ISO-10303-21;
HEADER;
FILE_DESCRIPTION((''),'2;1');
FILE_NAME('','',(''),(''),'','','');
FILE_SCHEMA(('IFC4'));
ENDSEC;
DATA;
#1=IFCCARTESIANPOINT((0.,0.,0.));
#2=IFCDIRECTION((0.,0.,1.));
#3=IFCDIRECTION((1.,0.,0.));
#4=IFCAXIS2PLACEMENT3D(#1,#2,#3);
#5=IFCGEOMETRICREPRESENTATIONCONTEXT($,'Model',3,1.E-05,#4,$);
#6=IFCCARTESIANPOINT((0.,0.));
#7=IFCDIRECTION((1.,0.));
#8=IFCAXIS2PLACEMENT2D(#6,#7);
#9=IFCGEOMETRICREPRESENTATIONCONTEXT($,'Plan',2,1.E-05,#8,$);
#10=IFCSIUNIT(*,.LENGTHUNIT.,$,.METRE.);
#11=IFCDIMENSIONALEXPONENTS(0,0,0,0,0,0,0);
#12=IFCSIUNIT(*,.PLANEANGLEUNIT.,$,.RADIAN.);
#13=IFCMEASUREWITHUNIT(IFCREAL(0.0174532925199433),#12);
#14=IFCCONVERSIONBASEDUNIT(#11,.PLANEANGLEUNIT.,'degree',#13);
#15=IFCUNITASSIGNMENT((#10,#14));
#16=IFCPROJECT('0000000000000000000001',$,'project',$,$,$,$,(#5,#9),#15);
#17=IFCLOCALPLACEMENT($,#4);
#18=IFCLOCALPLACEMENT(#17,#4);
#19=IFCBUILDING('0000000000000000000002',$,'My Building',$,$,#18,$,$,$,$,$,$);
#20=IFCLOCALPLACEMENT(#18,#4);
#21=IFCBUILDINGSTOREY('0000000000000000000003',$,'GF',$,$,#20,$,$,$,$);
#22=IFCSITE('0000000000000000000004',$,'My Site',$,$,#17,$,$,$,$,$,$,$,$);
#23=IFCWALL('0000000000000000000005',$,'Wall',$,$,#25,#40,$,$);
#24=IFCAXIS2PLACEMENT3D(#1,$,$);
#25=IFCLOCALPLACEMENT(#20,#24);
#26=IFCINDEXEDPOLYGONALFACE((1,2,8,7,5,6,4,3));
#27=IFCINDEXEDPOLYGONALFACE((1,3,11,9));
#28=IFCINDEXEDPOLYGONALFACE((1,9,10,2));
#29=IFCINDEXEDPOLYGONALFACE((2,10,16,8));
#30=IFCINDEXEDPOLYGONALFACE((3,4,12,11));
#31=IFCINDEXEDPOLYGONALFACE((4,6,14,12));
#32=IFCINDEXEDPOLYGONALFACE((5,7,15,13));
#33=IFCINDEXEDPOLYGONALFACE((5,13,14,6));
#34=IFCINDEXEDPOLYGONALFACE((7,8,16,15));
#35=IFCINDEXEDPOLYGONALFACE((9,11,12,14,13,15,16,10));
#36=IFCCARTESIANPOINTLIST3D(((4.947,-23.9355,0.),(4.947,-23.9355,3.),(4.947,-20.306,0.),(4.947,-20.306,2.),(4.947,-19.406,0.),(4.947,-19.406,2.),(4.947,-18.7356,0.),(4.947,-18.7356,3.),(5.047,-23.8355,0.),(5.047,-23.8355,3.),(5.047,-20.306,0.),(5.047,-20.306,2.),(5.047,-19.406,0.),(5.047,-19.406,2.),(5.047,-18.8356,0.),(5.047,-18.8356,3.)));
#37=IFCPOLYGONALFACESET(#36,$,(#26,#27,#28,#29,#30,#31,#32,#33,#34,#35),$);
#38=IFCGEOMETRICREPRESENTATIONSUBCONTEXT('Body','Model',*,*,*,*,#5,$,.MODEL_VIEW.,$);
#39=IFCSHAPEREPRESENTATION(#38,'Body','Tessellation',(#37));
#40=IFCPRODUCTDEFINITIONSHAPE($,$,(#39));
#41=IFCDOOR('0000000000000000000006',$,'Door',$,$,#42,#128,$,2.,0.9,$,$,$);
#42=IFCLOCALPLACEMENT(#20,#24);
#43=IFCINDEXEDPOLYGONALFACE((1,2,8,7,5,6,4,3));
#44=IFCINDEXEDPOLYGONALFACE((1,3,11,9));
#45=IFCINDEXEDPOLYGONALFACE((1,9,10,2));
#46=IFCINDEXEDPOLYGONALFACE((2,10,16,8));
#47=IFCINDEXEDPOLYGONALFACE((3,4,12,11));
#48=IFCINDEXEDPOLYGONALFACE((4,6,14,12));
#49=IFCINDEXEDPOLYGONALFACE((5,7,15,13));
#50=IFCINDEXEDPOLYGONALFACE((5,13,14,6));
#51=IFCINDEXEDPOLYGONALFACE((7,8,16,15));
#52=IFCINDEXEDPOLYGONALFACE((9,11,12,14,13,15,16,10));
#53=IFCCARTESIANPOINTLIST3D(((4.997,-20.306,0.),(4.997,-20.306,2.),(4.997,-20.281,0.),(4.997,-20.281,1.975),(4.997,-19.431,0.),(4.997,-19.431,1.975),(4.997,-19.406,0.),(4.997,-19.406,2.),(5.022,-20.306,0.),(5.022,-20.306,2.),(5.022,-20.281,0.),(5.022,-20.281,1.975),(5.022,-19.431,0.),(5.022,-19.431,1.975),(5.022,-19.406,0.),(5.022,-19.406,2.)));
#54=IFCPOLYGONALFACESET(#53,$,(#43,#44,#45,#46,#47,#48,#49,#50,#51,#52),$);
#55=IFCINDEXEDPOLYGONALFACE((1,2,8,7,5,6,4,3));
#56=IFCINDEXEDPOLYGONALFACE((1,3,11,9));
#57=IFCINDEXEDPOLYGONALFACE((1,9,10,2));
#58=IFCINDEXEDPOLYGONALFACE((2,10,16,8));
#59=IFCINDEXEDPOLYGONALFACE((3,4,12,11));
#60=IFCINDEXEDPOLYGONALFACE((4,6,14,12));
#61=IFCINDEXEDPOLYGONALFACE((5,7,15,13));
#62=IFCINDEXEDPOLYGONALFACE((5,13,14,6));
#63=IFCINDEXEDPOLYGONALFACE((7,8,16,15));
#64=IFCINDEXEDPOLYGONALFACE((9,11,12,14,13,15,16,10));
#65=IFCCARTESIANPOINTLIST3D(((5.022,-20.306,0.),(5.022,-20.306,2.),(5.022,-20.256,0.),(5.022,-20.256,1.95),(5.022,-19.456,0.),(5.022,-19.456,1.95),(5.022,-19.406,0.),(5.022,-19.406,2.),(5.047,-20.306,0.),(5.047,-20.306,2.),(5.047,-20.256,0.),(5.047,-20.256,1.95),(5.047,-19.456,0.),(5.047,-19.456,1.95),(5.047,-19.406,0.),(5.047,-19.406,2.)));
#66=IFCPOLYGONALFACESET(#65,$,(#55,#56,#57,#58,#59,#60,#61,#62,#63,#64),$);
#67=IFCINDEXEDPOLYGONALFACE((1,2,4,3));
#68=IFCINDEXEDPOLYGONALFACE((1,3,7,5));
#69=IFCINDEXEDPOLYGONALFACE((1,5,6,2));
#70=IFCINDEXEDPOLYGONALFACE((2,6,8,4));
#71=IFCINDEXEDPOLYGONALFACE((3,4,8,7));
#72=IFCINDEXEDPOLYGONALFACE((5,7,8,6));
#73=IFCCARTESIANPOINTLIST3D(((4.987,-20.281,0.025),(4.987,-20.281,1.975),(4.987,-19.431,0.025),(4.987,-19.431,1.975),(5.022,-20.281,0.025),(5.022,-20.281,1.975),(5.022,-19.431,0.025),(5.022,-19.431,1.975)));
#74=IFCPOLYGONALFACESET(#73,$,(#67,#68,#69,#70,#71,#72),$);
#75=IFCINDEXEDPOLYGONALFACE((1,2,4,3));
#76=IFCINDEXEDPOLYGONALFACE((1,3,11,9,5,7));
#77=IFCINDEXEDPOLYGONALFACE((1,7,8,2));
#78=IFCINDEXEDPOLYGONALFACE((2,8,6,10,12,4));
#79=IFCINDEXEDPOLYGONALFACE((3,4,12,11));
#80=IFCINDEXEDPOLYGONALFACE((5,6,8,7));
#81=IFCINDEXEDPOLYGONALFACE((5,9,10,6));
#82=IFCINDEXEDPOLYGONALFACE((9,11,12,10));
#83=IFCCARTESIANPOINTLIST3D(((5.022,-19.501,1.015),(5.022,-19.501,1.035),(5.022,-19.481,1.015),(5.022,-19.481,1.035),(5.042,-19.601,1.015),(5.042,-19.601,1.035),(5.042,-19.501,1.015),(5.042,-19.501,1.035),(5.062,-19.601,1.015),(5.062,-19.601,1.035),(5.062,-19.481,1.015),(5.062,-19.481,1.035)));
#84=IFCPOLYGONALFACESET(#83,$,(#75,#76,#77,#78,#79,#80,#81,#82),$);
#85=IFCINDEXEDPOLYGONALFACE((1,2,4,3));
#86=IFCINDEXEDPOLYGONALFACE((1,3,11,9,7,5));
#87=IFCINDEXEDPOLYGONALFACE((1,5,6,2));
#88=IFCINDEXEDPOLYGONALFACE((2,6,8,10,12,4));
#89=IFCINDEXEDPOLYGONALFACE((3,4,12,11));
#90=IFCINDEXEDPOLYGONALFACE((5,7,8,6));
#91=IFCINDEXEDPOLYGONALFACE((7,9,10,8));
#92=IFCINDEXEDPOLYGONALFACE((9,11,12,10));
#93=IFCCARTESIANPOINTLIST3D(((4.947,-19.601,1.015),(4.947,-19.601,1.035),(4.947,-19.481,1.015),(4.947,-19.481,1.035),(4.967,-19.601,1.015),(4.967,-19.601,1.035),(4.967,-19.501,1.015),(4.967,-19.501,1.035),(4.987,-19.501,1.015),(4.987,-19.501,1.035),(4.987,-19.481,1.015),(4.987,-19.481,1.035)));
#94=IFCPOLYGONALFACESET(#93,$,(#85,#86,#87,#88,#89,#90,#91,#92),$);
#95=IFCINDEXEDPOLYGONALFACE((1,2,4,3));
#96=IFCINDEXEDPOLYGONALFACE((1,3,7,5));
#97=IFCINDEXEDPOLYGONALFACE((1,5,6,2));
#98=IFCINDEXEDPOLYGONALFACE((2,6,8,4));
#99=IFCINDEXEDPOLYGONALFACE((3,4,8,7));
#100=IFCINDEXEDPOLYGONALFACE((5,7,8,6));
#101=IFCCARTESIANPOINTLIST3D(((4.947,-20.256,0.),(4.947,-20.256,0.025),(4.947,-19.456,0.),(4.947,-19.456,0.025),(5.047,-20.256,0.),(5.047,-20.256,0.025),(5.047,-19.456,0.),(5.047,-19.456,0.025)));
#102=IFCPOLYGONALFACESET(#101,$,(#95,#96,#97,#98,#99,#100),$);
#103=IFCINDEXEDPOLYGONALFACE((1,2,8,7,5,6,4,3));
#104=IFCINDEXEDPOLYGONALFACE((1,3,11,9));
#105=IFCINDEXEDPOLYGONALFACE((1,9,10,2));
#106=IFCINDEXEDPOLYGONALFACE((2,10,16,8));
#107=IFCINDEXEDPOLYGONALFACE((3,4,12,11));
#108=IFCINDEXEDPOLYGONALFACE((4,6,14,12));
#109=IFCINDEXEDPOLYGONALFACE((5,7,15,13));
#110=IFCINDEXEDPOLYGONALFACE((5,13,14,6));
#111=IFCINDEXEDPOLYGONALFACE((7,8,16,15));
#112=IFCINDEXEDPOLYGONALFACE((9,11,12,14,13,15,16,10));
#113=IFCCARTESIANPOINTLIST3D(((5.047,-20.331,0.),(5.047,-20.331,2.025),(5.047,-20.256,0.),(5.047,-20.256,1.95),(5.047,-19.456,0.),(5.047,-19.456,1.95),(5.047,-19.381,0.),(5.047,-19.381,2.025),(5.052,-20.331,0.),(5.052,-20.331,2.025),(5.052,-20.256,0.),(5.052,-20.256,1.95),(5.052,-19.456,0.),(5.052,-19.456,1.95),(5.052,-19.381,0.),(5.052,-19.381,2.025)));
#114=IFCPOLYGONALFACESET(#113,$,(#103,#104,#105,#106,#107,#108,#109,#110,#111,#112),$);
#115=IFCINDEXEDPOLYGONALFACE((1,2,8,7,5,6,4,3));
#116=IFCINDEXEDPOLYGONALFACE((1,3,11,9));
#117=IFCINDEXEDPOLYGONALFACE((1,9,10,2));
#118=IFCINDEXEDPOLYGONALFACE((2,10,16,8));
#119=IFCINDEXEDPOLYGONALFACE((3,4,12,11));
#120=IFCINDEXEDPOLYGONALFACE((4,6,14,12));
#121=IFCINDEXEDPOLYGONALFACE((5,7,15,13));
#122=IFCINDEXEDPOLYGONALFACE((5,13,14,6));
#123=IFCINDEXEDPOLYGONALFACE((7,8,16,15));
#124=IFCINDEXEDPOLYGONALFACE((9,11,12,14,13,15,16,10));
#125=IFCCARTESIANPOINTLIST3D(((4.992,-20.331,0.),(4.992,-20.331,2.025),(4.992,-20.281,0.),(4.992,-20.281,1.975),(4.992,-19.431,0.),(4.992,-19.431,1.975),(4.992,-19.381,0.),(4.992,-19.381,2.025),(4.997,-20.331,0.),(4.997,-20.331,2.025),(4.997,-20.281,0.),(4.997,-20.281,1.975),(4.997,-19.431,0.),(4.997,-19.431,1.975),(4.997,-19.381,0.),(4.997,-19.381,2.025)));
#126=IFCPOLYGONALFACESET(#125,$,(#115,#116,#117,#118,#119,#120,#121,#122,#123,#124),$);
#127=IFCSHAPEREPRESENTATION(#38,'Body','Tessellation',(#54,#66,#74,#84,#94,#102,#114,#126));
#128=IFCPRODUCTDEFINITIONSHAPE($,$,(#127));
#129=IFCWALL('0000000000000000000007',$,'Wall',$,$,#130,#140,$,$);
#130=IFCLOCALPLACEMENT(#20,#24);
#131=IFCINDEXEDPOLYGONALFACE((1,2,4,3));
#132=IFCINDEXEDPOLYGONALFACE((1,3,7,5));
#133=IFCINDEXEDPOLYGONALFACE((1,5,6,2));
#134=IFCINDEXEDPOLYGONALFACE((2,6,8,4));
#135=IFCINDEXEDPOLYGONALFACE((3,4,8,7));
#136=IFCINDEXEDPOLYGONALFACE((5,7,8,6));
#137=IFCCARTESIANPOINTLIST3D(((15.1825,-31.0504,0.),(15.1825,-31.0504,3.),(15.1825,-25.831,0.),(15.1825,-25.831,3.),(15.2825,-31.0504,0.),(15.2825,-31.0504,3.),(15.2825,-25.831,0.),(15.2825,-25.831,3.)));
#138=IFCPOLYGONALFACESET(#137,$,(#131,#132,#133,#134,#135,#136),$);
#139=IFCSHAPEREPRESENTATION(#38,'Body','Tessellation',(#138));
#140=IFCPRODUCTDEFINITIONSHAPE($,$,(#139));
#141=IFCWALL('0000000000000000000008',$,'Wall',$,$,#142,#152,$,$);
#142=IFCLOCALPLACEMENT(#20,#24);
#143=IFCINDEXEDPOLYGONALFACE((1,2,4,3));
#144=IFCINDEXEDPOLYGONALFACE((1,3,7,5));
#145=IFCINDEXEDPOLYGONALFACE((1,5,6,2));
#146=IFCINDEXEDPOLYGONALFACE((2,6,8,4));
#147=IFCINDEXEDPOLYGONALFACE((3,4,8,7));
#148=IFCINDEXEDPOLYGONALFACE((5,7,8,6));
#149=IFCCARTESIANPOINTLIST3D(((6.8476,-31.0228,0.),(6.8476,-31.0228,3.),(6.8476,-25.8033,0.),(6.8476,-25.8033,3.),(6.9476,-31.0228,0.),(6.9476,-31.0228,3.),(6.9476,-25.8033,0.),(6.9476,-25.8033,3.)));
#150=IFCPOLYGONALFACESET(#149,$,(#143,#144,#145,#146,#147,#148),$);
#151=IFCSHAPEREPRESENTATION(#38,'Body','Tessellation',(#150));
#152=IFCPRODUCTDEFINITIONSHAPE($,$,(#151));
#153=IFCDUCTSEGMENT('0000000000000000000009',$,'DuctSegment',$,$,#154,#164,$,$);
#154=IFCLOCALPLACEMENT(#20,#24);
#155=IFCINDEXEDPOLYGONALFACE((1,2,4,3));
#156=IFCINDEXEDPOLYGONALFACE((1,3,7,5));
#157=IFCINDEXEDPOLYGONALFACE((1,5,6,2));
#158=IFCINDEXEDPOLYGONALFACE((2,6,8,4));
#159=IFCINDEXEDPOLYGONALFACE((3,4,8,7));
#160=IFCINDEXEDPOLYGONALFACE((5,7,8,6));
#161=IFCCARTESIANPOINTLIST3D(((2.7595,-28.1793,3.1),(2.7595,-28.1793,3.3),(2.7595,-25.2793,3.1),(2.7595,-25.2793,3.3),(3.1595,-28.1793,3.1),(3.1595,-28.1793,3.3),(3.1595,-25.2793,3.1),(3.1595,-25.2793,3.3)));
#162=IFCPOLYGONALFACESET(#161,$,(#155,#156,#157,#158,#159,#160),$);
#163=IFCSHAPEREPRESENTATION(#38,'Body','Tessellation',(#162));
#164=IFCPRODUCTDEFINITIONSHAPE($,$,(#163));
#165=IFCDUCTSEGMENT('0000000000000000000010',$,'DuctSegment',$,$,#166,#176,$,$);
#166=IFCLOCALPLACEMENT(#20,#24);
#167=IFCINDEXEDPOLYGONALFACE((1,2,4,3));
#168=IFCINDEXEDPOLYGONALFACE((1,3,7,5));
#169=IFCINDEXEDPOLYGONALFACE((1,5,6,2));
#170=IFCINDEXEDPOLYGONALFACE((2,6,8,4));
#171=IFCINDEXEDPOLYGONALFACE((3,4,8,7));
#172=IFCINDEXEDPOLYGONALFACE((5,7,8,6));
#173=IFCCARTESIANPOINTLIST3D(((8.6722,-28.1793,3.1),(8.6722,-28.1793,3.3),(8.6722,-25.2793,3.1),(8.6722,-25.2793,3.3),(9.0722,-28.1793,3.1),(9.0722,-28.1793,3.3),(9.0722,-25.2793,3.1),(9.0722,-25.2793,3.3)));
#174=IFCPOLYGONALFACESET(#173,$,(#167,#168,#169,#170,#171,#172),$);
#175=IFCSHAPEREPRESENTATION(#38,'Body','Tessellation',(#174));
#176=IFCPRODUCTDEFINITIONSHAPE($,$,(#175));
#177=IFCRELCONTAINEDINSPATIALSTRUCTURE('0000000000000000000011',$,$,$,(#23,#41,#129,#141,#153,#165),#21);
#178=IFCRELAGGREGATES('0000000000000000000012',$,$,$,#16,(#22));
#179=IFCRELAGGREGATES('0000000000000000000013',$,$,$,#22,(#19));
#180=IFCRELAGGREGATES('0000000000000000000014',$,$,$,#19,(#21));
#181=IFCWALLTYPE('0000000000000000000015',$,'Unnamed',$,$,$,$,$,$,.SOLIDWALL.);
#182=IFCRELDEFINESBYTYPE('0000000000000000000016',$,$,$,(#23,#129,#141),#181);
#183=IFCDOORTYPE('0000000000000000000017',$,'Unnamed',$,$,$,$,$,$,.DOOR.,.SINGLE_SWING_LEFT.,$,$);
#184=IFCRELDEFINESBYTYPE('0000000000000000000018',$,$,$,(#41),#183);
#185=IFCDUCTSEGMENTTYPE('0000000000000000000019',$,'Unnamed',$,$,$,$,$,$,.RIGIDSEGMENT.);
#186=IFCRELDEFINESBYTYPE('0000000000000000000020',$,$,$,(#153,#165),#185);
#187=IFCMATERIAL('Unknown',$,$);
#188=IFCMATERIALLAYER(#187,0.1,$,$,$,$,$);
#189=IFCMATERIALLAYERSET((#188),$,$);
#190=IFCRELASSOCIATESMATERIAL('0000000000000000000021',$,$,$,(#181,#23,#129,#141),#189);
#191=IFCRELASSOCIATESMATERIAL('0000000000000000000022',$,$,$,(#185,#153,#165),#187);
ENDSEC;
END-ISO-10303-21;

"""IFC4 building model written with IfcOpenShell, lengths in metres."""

from ifc_helpers import new_model, entity, si_unit, converted_unit, frame, origin_with_axes, origin_2d_with_axis, place, context, subcontext, project, spatial, line, indexed_curve, rectangle, outline, extrude, shape, source, transform, mapped, material, layer, layer_set, layer_usage, material_profile, profile_set, profile_usage, type_object, type_shapes, element, fill, save


model = new_model("IFC4")

# Units and contexts
model_context = context("Model", 3, precision=1e-05, world=origin_with_axes())
plan_context = context("Plan", 2, precision=1e-05, world=origin_2d_with_axis())
body_context_1 = subcontext(model_context, "Body", "Model", "MODEL_VIEW")
body_context_2 = subcontext(plan_context, "Body", "Plan", "PLAN_VIEW")
ifc_project = project(units=[si_unit("LENGTHUNIT", "METRE"), converted_unit("PLANEANGLEUNIT", "degree", entity("IfcReal", 0.0174532925199433), si_unit("PLANEANGLEUNIT", "RADIAN"), dimensions=[0, 0, 0, 0, 0, 0, 0])], contexts=[model_context, plan_context])

# Site, building, storey
site_placement = place(None, origin_with_axes())
site = spatial("IfcSite", under=ifc_project, at=site_placement, Name="My Site")
building_placement = place(site_placement, origin_with_axes())
building = spatial("IfcBuilding", under=site, at=building_placement, Name="My Building")
storey_placement = place(building_placement, origin_with_axes())
storey = spatial("IfcBuildingStorey", under=building, at=storey_placement, Name="GF")

# Shared definitions
ifc_material = material(Name="Unknown")
ifc_layer = layer(ifc_material, 0.1)
ifc_layer_set = layer_set([ifc_layer])
wall_type = type_object("IfcWallType", Name="Unnamed", PredefinedType="SOLIDWALL", material=ifc_layer_set)

# Shared definitions
shared_shape_1 = source(origin_with_axes(), body_context_1, "Body", "SweptSolid", [
    extrude(outline(indexed_curve([(0.0, 0.0), (0.9, 0.0), (0.9, 2.0), (0.0, 2.0)], segments=[line(1, 2, 3, 4, 1)])), frame((0.0, -0.6, 0.0), z_axis=(0.0, -1.0, 0.0), x_axis=(1.0, 0.0, 0.0)), (0.0, 0.0, -1.0), 1.2),
])
door_type = type_object("IfcDoorType", Name="Unnamed", OperationType="SINGLE_SWING_LEFT", PredefinedType="DOOR")
shared_shape_2 = source(origin_with_axes(), body_context_1, "Body", "SweptSolid", [
    extrude(outline(indexed_curve([(0.0, 0.0), (0.0, 2.0), (0.9, 2.0), (0.9, 0.0), (0.875, 0.0), (0.875, 1.975), (0.025, 1.975), (0.025, 0.0)], segments=[line(1, 2, 3, 4, 5, 6, 7, 8, 1)])), frame((0.0, 0.025, 0.0), z_axis=(0.0, -1.0, 0.0), x_axis=(1.0, 0.0, 0.0)), (0.0, 0.0, -1.0), 0.025),
    extrude(outline(indexed_curve([(0.0, 0.0), (0.0, 2.0), (0.9, 2.0), (0.9, 0.0), (0.85, 0.0), (0.85, 1.95), (0.05, 1.95), (0.05, 0.0)], segments=[line(1, 2, 3, 4, 5, 6, 7, 8, 1)])), frame((0.0, 0.0, 0.0), z_axis=(0.0, -1.0, 0.0), x_axis=(1.0, 0.0, 0.0)), (0.0, 0.0, -1.0), 0.025),
    extrude(outline(indexed_curve([(0.0, 0.0), (0.85, 0.0), (0.85, 0.035), (0.0, 0.035)], segments=[line(1, 2, 3, 4, 1)])), frame((0.025, 0.025, 0.025), z_axis=(0.0, 0.0, 1.0), x_axis=(1.0, 0.0, 0.0)), (0.0, 0.0, 1.0), 1.95),
    extrude(outline(indexed_curve([(0.0, 0.0), (0.0, -0.04), (-0.12, -0.04), (-0.12, -0.02), (-0.02, -0.02), (-0.02, 0.0)], segments=[line(1, 2, 3, 4, 5, 6, 1)])), frame((0.825, 0.025, 1.015), z_axis=(0.0, 0.0, 1.0), x_axis=(1.0, 0.0, 0.0)), (0.0, 0.0, 1.0), 0.02),
    extrude(outline(indexed_curve([(0.0, 0.0), (0.0, 0.04), (-0.12, 0.04), (-0.12, 0.02), (-0.02, 0.02), (-0.02, 0.0)], segments=[line(1, 2, 3, 4, 5, 6, 1)])), frame((0.825, 0.06, 1.015), z_axis=(0.0, 0.0, 1.0), x_axis=(1.0, 0.0, 0.0)), (0.0, 0.0, 1.0), 0.02),
    extrude(outline(indexed_curve([(0.0, 0.0), (0.8, 0.0), (0.8, 0.1), (0.0, 0.1)], segments=[line(1, 2, 3, 4, 1)])), frame((0.05, 0.0, 0.0), z_axis=(0.0, 0.0, 1.0), x_axis=(1.0, 0.0, 0.0)), (0.0, 0.0, 1.0), 0.025),
    extrude(outline(indexed_curve([(0.0, 0.0), (0.0, 2.025), (0.95, 2.025), (0.95, 0.0), (0.875, 0.0), (0.875, 1.95), (0.075, 1.95), (0.075, 0.0)], segments=[line(1, 2, 3, 4, 5, 6, 7, 8, 1)])), frame((-0.025, -0.005, 0.0), z_axis=(0.0, -1.0, 0.0), x_axis=(1.0, 0.0, 0.0)), (0.0, 0.0, -1.0), 0.005),
    extrude(outline(indexed_curve([(0.0, 0.0), (0.0, 2.025), (0.95, 2.025), (0.95, 0.0), (0.9, 0.0), (0.9, 1.975), (0.05, 1.975), (0.05, 0.0)], segments=[line(1, 2, 3, 4, 5, 6, 7, 8, 1)])), frame((-0.025, 0.05, 0.0), z_axis=(0.0, -1.0, 0.0), x_axis=(1.0, 0.0, 0.0)), (0.0, 0.0, -1.0), 0.005),
])
shared_shape_3 = source(origin_with_axes(), body_context_2, "Body", "Curve2D", [
    entity("IfcIndexedPolyCurve", entity("IfcCartesianPointList2D", [[0.0, 0.0], [0.0, 0.05], [0.025, 0.05], [0.025, 0.025], [0.05, 0.025], [0.05, 0.0]]), [entity("IfcLineIndex", [1, 2, 3, 4, 5, 6, 1])]),
    entity("IfcIndexedPolyCurve", entity("IfcCartesianPointList2D", [[0.9, 0.0], [0.9, 0.05], [0.875, 0.05], [0.875, 0.025], [0.85, 0.025], [0.85, 0.0]]), [entity("IfcLineIndex", [1, 2, 3, 4, 5, 6, 1])]),
    entity("IfcTrimmedCurve", entity("IfcEllipse", entity("IfcAxis2Placement2D", entity("IfcCartesianPoint", [0.06, 0.05]), entity("IfcDirection", [1.0, 0.0])), 0.815, 0.85), [entity("IfcCartesianPoint", [0.875, 0.05])], [entity("IfcCartesianPoint", [0.06, 0.9])], True, "CARTESIAN"),
    entity("IfcIndexedPolyCurve", entity("IfcCartesianPointList2D", [[0.025, 0.05], [0.06, 0.05], [0.06, 0.9], [0.025, 0.9]]), [entity("IfcLineIndex", [1, 2, 3, 4, 1])]),
])
type_shapes(door_type, [shared_shape_2, shared_shape_3])

# Wall, opening, door
ifc_layer_usage_1 = layer_usage(ifc_layer_set, "AXIS2", "POSITIVE", 0.0)
wall_1_placement = place(storey_placement, frame((5.047, -23.8355, 0.0), z_axis=(0.0, 0.0, 1.0), x_axis=(0.0, 1.0, 0.0)))
wall_1 = element("IfcWall", 1, at=wall_1_placement, inside=storey, type_object=wall_type, material=ifc_layer_usage_1, Name="Wall", context=body_context_1, shape_type="SweptSolid", body=[
    extrude(outline(indexed_curve([(0.0, 0.0), (-0.1, 0.1), (5.1, 0.1), (5.0, 0.0)], segments=[line(1, 2, 3, 4, 1)])), origin_with_axes(), (0.0, 0.0, 1.0), 3.0),
])
opening_1_placement = place(wall_1_placement, frame((3.5295, 0.0, 0.0), z_axis=(0.0, 0.0, 1.0), x_axis=(1.0, 0.0, 0.0)))
opening_1 = element("IfcOpeningElement", 2, at=opening_1_placement, cuts=wall_1, PredefinedType="OPENING", context=body_context_1, shape_type="MappedRepresentation", body=[
    mapped(shared_shape_1, transform((0.0, 0.0, 0.0), x_axis=(1.0, 0.0, 0.0), y_axis=(0.0, 1.0, 0.0), z_axis=(0.0, 0.0, 1.0), scale=1.0)),
])
door_1_placement = place(opening_1_placement, frame((0.0, 0.0, 0.0), z_axis=(0.0, 0.0, 1.0), x_axis=(1.0, 0.0, 0.0)))
door_1 = element("IfcDoor", 3, at=door_1_placement, inside=storey, type_object=door_type, Name="Door", OverallHeight=2.0, OverallWidth=0.9, shapes=[
    shape(body_context_1, "Body", "MappedRepresentation", [mapped(shared_shape_2, transform((0.0, 0.0, 0.0), x_axis=(1.0, 0.0, 0.0), y_axis=(0.0, 1.0, 0.0), z_axis=(0.0, 0.0, 1.0), scale=1.0))]),
    shape(body_context_2, "Body", "MappedRepresentation", [mapped(shared_shape_3, transform((0.0, 0.0, 0.0), x_axis=(1.0, 0.0, 0.0), y_axis=(0.0, 1.0, 0.0), z_axis=(0.0, 0.0, 1.0), scale=1.0))]),
])
fill(opening_1, door_1)

# Walls
ifc_layer_usage_2 = layer_usage(ifc_layer_set, "AXIS2", "POSITIVE", 0.0)
wall_2_placement = place(storey_placement, frame((15.1825, -25.831, 0.0), z_axis=(0.0, 0.0, 1.0), x_axis=(0.0, -1.0, 0.0)))
element("IfcWall", 4, at=wall_2_placement, inside=storey, type_object=wall_type, material=ifc_layer_usage_2, Name="Wall", context=body_context_1, shape_type="SweptSolid", body=[
    extrude(outline(indexed_curve([(0.0, 0.0), (0.0, 0.1), (5.2194, 0.1), (5.2194, 0.0)], segments=[line(1, 2, 3, 4, 1)])), origin_with_axes(), (0.0, 0.0, 1.0), 3.0),
])
ifc_layer_usage_3 = layer_usage(ifc_layer_set, "AXIS2", "POSITIVE", 0.0)
wall_3_placement = place(storey_placement, frame((6.8476, -25.8033, 0.0), z_axis=(0.0, 0.0, 1.0), x_axis=(0.0, -1.0, 0.0)))
element("IfcWall", 5, at=wall_3_placement, inside=storey, type_object=wall_type, material=ifc_layer_usage_3, Name="Wall", context=body_context_1, shape_type="SweptSolid", body=[
    extrude(outline(indexed_curve([(0.0, 0.0), (0.0, 0.1), (5.2195, 0.1), (5.2195, 0.0)], segments=[line(1, 2, 3, 4, 1)])), origin_with_axes(), (0.0, 0.0, 1.0), 3.0),
])

# Duct segments
ifc_material_profile_1 = material_profile(ifc_material, rectangle(XDim=0.4, YDim=0.2))
ifc_profile_set_1 = profile_set([ifc_material_profile_1])
ifc_profile_usage_1 = profile_usage(ifc_profile_set_1, cardinal=5)
duct_segment_type = type_object("IfcDuctSegmentType", Name="Unnamed", PredefinedType="RIGIDSEGMENT", material=ifc_profile_set_1)
duct_segment_1_placement = place(storey_placement, frame((2.9595, -25.2793, 3.2), z_axis=(0.0, -1.0, 0.0), x_axis=(1.0, 0.0, 0.0)))
element("IfcDuctSegment", 6, at=duct_segment_1_placement, inside=storey, type_object=duct_segment_type, material=ifc_profile_usage_1, Name="DuctSegment", context=body_context_1, shape_type="SweptSolid", body=[
    extrude(rectangle(XDim=0.4, YDim=0.2), origin_with_axes(), (0.0, 0.0, 1.0), 2.9),
])
ifc_profile_usage_2 = profile_usage(ifc_profile_set_1, cardinal=5)
duct_segment_2_placement = place(storey_placement, frame((8.8722, -25.2793, 3.2), z_axis=(0.0, -1.0, 0.0), x_axis=(1.0, 0.0, 0.0)))
element("IfcDuctSegment", 7, at=duct_segment_2_placement, inside=storey, type_object=duct_segment_type, material=ifc_profile_usage_2, Name="DuctSegment", context=body_context_1, shape_type="SweptSolid", body=[
    extrude(rectangle(XDim=0.4, YDim=0.2), origin_with_axes(), (0.0, 0.0, 1.0), 2.9),
])

save(model, "model.ifc")
